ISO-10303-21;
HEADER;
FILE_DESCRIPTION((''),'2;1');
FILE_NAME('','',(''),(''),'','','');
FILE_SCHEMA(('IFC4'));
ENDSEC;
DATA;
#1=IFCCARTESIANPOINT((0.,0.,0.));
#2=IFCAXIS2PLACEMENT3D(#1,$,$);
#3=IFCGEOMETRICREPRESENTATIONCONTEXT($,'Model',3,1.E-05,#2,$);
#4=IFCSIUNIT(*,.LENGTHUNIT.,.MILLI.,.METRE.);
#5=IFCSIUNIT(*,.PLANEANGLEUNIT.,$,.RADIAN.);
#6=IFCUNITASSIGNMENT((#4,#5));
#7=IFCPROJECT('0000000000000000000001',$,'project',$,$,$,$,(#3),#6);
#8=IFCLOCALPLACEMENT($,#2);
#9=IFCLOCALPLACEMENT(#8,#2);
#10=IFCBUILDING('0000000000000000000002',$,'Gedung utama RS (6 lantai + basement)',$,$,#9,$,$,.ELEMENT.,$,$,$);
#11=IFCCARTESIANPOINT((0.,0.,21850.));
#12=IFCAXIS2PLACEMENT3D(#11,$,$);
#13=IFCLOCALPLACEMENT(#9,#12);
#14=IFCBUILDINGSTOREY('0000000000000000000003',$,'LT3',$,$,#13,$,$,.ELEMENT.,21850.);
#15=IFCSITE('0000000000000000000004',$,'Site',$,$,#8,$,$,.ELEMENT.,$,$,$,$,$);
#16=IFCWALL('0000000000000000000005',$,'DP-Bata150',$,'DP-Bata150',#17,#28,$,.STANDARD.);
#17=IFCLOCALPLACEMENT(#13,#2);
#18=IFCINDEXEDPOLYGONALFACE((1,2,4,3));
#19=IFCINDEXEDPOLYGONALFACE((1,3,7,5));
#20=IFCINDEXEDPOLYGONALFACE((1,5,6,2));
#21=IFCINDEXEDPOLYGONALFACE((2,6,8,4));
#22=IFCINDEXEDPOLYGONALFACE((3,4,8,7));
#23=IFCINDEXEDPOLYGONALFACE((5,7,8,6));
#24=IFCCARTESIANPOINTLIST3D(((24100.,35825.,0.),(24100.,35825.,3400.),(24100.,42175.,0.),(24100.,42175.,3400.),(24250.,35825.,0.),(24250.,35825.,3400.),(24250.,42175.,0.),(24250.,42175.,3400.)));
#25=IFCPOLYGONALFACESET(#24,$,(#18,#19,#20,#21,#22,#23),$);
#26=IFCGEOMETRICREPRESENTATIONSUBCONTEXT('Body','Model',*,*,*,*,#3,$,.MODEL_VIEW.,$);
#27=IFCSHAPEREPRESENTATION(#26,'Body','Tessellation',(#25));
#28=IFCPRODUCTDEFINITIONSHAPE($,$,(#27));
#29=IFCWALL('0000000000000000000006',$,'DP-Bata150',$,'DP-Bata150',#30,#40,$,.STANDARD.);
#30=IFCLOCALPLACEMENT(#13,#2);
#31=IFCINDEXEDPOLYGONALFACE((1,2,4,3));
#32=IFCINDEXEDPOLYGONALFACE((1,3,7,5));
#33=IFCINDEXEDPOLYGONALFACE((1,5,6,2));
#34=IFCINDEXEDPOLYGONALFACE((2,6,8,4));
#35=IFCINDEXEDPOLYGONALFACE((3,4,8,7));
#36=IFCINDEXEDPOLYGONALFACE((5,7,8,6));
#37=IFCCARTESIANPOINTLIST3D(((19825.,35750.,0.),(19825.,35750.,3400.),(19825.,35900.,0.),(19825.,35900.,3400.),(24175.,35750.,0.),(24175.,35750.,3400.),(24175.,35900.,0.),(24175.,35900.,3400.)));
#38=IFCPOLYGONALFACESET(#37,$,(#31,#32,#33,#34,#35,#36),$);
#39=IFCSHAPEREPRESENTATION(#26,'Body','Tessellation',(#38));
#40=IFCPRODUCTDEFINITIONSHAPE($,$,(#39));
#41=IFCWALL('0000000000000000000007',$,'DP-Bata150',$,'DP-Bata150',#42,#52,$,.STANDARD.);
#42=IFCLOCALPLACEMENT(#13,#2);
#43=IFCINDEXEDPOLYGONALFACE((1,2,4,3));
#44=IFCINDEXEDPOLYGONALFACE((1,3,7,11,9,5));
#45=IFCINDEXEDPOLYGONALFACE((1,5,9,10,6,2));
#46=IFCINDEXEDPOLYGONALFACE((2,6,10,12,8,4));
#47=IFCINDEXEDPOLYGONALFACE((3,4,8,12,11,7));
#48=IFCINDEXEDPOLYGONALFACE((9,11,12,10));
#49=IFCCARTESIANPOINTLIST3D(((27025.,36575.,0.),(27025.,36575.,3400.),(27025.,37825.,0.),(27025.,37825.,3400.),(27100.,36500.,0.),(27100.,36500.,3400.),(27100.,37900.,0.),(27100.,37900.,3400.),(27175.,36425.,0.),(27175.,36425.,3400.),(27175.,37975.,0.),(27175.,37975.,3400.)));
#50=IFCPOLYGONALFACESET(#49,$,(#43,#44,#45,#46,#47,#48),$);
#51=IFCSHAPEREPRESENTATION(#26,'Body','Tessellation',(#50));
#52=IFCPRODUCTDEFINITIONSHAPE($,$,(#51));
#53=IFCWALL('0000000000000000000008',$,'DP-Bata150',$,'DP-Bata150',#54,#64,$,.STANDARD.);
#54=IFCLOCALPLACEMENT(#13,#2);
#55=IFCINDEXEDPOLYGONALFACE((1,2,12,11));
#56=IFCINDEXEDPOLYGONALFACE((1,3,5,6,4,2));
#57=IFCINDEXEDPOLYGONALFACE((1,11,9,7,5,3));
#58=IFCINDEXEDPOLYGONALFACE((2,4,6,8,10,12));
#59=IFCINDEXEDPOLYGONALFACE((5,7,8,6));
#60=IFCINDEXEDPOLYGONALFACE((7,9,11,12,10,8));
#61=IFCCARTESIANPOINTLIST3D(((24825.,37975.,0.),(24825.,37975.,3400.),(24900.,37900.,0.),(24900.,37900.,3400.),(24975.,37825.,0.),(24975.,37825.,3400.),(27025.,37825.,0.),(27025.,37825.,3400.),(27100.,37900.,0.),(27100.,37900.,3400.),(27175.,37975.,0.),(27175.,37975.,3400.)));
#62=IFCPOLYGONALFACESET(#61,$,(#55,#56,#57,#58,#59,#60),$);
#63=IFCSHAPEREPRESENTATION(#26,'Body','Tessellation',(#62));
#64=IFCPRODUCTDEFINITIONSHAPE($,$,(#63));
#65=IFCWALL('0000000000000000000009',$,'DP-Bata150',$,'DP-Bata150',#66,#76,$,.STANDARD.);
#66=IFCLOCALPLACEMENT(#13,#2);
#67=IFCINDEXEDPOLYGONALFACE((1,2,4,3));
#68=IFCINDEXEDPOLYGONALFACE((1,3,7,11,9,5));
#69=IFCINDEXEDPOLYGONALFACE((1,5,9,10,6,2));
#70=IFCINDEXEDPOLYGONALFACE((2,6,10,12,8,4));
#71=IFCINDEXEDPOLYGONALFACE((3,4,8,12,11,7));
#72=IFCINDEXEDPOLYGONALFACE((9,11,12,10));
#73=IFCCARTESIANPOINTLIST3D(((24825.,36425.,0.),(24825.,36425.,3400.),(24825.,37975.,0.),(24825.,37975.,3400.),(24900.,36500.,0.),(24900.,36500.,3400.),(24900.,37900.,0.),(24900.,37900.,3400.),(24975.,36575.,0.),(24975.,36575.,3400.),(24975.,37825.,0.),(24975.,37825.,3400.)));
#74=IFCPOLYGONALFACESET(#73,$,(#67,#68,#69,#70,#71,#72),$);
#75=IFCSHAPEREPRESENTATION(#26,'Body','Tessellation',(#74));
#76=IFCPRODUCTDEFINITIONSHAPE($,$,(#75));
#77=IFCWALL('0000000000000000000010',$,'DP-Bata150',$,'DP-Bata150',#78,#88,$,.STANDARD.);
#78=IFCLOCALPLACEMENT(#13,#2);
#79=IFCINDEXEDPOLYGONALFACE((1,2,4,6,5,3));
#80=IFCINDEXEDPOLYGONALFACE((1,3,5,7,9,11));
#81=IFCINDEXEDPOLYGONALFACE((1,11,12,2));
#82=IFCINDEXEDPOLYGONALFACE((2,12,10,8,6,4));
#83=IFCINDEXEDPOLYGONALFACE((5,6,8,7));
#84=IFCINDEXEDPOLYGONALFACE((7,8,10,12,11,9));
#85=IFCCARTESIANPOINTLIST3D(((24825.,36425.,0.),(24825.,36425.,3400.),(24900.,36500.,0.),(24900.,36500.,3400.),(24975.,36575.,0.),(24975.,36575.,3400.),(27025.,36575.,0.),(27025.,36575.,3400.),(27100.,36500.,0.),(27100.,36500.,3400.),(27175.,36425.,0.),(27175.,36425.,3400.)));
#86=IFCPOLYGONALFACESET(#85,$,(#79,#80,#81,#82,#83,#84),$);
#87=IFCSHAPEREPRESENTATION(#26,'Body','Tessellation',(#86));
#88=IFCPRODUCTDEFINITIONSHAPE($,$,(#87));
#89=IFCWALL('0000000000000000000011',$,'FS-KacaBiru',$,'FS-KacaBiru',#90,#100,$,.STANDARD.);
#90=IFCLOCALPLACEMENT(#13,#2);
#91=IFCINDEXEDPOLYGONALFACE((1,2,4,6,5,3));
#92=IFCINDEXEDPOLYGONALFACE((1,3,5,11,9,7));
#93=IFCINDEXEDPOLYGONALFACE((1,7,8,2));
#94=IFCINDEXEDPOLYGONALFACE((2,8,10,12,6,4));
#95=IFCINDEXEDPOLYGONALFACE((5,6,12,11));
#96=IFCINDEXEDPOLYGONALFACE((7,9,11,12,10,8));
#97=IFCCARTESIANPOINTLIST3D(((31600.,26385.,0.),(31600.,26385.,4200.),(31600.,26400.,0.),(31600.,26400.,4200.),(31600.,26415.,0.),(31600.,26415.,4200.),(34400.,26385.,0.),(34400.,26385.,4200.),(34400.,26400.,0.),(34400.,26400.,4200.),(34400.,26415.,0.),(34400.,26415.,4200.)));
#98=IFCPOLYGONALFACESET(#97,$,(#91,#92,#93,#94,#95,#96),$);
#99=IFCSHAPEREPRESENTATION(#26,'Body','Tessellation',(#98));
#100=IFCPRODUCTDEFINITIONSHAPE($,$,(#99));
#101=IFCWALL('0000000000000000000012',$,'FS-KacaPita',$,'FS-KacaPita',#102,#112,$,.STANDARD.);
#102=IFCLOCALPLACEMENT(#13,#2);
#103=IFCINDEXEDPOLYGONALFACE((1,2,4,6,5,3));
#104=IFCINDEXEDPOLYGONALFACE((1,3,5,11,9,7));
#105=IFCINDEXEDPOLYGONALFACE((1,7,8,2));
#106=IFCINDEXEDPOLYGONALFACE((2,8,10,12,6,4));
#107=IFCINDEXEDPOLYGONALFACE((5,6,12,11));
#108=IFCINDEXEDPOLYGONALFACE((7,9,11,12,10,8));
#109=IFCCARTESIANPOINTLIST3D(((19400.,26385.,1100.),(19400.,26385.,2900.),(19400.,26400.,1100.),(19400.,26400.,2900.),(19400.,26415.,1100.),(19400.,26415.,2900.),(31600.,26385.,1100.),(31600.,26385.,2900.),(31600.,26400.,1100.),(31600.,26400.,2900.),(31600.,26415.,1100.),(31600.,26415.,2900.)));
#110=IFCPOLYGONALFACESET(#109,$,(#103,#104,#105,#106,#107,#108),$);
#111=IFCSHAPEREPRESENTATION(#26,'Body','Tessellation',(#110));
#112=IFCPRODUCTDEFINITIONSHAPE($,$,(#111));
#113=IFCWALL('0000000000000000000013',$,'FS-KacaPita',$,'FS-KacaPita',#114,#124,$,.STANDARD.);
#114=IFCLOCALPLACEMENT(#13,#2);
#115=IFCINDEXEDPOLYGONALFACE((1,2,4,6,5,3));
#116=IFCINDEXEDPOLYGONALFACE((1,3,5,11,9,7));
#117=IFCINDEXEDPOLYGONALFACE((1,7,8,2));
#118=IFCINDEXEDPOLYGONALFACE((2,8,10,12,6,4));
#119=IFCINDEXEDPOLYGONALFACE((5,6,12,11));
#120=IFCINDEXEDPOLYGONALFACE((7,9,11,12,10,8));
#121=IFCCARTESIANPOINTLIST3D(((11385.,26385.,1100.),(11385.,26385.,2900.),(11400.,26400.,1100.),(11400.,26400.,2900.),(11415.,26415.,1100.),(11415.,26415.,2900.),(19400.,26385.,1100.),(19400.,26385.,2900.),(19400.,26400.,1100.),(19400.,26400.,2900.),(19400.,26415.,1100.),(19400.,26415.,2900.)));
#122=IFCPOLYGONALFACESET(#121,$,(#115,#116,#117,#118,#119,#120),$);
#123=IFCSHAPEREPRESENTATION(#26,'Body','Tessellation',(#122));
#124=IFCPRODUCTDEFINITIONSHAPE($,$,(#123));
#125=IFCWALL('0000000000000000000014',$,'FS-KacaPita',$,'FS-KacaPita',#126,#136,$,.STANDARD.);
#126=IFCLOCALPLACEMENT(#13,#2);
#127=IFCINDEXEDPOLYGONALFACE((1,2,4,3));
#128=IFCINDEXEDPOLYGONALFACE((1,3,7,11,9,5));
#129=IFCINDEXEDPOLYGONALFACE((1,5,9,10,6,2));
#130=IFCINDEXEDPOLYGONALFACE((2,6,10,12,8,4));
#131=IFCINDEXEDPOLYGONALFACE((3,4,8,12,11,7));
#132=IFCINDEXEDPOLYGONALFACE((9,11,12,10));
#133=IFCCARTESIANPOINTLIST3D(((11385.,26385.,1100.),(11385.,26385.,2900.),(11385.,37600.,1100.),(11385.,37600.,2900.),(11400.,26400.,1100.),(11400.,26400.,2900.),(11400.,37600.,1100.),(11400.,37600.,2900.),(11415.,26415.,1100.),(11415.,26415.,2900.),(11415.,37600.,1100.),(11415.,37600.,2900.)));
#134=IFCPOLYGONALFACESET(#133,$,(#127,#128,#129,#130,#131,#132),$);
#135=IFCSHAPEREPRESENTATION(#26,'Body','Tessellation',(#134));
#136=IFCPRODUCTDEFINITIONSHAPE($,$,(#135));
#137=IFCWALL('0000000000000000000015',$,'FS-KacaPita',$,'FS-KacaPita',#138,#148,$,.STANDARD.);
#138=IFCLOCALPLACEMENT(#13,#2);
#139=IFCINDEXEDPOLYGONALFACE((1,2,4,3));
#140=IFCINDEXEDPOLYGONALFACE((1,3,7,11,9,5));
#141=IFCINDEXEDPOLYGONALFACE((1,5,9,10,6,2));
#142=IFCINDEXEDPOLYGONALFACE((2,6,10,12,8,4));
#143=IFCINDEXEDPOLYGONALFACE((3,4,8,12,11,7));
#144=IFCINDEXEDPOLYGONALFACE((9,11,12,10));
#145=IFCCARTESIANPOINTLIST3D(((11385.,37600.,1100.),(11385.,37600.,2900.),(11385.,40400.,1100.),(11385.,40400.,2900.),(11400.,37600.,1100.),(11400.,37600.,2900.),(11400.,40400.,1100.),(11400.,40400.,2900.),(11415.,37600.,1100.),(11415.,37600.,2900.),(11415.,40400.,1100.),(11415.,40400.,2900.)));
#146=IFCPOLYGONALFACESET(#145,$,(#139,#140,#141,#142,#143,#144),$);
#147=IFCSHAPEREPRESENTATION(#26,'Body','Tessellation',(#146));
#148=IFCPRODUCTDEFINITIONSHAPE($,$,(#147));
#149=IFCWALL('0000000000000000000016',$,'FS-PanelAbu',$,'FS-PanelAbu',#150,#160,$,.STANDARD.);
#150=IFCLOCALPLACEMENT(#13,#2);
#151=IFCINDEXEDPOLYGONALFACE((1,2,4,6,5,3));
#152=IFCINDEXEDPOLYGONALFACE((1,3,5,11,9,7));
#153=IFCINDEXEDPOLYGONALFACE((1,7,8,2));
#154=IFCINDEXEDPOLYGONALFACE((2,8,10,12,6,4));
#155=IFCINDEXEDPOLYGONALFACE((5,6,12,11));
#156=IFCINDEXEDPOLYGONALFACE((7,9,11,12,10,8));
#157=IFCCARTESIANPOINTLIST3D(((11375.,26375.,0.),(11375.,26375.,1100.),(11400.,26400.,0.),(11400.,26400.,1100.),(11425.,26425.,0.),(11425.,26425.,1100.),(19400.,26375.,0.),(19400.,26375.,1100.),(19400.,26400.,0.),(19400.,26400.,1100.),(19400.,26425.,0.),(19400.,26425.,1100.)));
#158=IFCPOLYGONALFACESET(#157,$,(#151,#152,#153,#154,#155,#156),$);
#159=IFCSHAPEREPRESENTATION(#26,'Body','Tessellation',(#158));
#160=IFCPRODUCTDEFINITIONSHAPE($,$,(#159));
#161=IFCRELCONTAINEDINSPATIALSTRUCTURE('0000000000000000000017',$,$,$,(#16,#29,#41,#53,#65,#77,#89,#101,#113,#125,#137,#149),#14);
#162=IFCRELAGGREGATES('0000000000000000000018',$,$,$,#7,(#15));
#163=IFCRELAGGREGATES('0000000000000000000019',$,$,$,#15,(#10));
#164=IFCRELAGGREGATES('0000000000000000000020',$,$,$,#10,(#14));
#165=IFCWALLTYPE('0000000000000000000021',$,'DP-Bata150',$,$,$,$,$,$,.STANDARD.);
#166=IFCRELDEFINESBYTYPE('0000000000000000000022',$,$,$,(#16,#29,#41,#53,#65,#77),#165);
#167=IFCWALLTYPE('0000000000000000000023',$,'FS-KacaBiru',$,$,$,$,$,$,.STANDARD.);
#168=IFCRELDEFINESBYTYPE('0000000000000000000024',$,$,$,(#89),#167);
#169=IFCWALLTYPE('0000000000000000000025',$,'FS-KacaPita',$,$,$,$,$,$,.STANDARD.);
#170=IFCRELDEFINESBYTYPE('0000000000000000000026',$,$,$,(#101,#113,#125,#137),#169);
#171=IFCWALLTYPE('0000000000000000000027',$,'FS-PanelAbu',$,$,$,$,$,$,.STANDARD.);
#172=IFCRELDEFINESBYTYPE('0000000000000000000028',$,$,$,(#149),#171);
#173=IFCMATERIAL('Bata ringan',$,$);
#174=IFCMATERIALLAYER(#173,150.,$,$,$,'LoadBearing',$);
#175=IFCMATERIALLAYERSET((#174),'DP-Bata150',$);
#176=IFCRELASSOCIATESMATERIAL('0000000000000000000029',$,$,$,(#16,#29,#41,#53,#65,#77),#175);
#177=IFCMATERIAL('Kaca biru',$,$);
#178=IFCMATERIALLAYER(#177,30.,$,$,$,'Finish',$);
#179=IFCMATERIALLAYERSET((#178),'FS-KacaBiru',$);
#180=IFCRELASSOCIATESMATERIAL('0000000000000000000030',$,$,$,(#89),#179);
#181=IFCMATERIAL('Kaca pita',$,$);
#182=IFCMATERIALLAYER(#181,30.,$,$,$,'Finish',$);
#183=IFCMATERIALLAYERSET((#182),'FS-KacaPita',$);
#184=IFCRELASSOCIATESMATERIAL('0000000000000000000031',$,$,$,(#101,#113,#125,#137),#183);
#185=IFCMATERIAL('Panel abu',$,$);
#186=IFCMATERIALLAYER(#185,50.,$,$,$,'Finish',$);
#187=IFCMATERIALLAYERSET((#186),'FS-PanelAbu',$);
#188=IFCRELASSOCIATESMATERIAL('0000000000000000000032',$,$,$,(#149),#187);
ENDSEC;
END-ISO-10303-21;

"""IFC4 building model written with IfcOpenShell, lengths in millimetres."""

from ifc_helpers import new_model, si_unit, frame, origin, place, context, subcontext, project, spatial, polyline, outline, extrude, material, layer, layer_set, layer_usage, type_object, element, save


model = new_model("IFC4")

# Units and contexts
model_context = context("Model", 3, precision=1e-05, world=origin())
body_context = subcontext(model_context, "Body", "Model", "MODEL_VIEW")
ifc_project = project(units=[si_unit("LENGTHUNIT", "METRE", prefix="MILLI"), si_unit("PLANEANGLEUNIT", "RADIAN")], contexts=[model_context])

# Site, building, storey
site_placement = place(None, origin())
site = spatial("IfcSite", under=ifc_project, at=site_placement, Name="Site", CompositionType="ELEMENT")
building_placement = place(site_placement, origin())
building = spatial("IfcBuilding", under=site, at=building_placement, Name="Gedung utama RS (6 lantai + basement)", CompositionType="ELEMENT")
storey_placement = place(building_placement, frame((0.0, 0.0, 21850.0)))
storey = spatial("IfcBuildingStorey", under=building, at=storey_placement, Name="LT3", CompositionType="ELEMENT", Elevation=21850.0)

# Shared definitions
ifc_material_1 = material(Name="Bata ringan")
ifc_layer_1 = layer(ifc_material_1, 150.0, Category="LoadBearing")
ifc_layer_set_1 = layer_set([ifc_layer_1], Name="DP-Bata150")
ifc_layer_usage_1 = layer_usage(ifc_layer_set_1, "AXIS2", "NEGATIVE", 75.0)
wall_type_1 = type_object("IfcWallType", Name="DP-Bata150", PredefinedType="STANDARD")

# Walls
wall_1_placement = place(storey_placement, frame((24175.0, 35825.0, 0.0), z_axis=(0.0, 0.0, 1.0), x_axis=(0.0, 1.0, 0.0)))
element("IfcWall", 1, at=wall_1_placement, inside=storey, type_object=wall_type_1, material=ifc_layer_usage_1, Name="DP-Bata150", ObjectType="DP-Bata150", PredefinedType="STANDARD", context=body_context, shape_type="SweptSolid", body=[
    extrude(outline(polyline([(0.0, -75.0), (0.0, 75.0), (6350.0, 75.0), (6350.0, -75.0), (0.0, -75.0)])), origin(), (0.0, 0.0, 1.0), 3400.0),
])
wall_2_placement = place(storey_placement, frame((19825.0, 35825.0, 0.0), z_axis=(0.0, 0.0, 1.0), x_axis=(1.0, 0.0, 0.0)))
element("IfcWall", 2, at=wall_2_placement, inside=storey, type_object=wall_type_1, material=ifc_layer_usage_1, Name="DP-Bata150", ObjectType="DP-Bata150", PredefinedType="STANDARD", context=body_context, shape_type="SweptSolid", body=[
    extrude(outline(polyline([(0.0, -75.0), (0.0, 75.0), (4350.0, 75.0), (4350.0, -75.0), (0.0, -75.0)])), origin(), (0.0, 0.0, 1.0), 3400.0),
])
wall_3_placement = place(storey_placement, frame((27100.0, 36500.0, 0.0), z_axis=(0.0, 0.0, 1.0), x_axis=(0.0, 1.0, 0.0)))
element("IfcWall", 3, at=wall_3_placement, inside=storey, type_object=wall_type_1, material=ifc_layer_usage_1, Name="DP-Bata150", ObjectType="DP-Bata150", PredefinedType="STANDARD", context=body_context, shape_type="SweptSolid", body=[
    extrude(outline(polyline([(-75.0, -75.0), (0.0, 0.0), (75.0, 75.0), (1325.0, 75.0), (1400.0, 0.0), (1475.0, -75.0), (-75.0, -75.0)])), origin(), (0.0, 0.0, 1.0), 3400.0),
])
wall_4_placement = place(storey_placement, frame((27100.0, 37900.0, 0.0), z_axis=(0.0, 0.0, 1.0), x_axis=(-1.0, 0.0, 0.0)))
element("IfcWall", 4, at=wall_4_placement, inside=storey, type_object=wall_type_1, material=ifc_layer_usage_1, Name="DP-Bata150", ObjectType="DP-Bata150", PredefinedType="STANDARD", context=body_context, shape_type="SweptSolid", body=[
    extrude(outline(polyline([(-75.0, -75.0), (0.0, 0.0), (75.0, 75.0), (2125.0, 75.0), (2200.0, 0.0), (2275.0, -75.0), (-75.0, -75.0)])), origin(), (0.0, 0.0, 1.0), 3400.0),
])
wall_5_placement = place(storey_placement, frame((24900.0, 37900.0, 0.0), z_axis=(0.0, 0.0, 1.0), x_axis=(0.0, -1.0, 0.0)))
element("IfcWall", 5, at=wall_5_placement, inside=storey, type_object=wall_type_1, material=ifc_layer_usage_1, Name="DP-Bata150", ObjectType="DP-Bata150", PredefinedType="STANDARD", context=body_context, shape_type="SweptSolid", body=[
    extrude(outline(polyline([(-75.0, -75.0), (0.0, 0.0), (75.0, 75.0), (1325.0, 75.0), (1400.0, 0.0), (1475.0, -75.0), (-75.0, -75.0)])), origin(), (0.0, 0.0, 1.0), 3400.0),
])
wall_6_placement = place(storey_placement, frame((24900.0, 36500.0, 0.0), z_axis=(0.0, 0.0, 1.0), x_axis=(1.0, 0.0, 0.0)))
element("IfcWall", 6, at=wall_6_placement, inside=storey, type_object=wall_type_1, material=ifc_layer_usage_1, Name="DP-Bata150", ObjectType="DP-Bata150", PredefinedType="STANDARD", context=body_context, shape_type="SweptSolid", body=[
    extrude(outline(polyline([(-75.0, -75.0), (0.0, 0.0), (75.0, 75.0), (2125.0, 75.0), (2200.0, 0.0), (2275.0, -75.0), (-75.0, -75.0)])), origin(), (0.0, 0.0, 1.0), 3400.0),
])
ifc_material_2 = material(Name="Kaca biru")
ifc_layer_2 = layer(ifc_material_2, 30.0, Category="Finish")
ifc_layer_set_2 = layer_set([ifc_layer_2], Name="FS-KacaBiru")
ifc_layer_usage_2 = layer_usage(ifc_layer_set_2, "AXIS2", "NEGATIVE", 15.0)
wall_type_2 = type_object("IfcWallType", Name="FS-KacaBiru", PredefinedType="STANDARD")
wall_7_placement = place(storey_placement, frame((34400.0, 26400.0, 0.0), z_axis=(0.0, 0.0, 1.0), x_axis=(-1.0, 0.0, 0.0)))
element("IfcWall", 7, at=wall_7_placement, inside=storey, type_object=wall_type_2, material=ifc_layer_usage_2, Name="FS-KacaBiru", ObjectType="FS-KacaBiru", PredefinedType="STANDARD", context=body_context, shape_type="SweptSolid", body=[
    extrude(outline(polyline([(0.0, -15.0), (0.0, 0.0), (0.0, 15.0), (2800.0, 15.0), (2800.0, 0.0), (2800.0, -15.0), (0.0, -15.0)])), origin(), (0.0, 0.0, 1.0), 4200.0),
])
ifc_material_3 = material(Name="Kaca pita")
ifc_layer_3 = layer(ifc_material_3, 30.0, Category="Finish")
ifc_layer_set_3 = layer_set([ifc_layer_3], Name="FS-KacaPita")
ifc_layer_usage_3 = layer_usage(ifc_layer_set_3, "AXIS2", "NEGATIVE", 15.0)
wall_type_3 = type_object("IfcWallType", Name="FS-KacaPita", PredefinedType="STANDARD")
wall_8_placement = place(storey_placement, frame((31600.0, 26400.0, 1100.0), z_axis=(0.0, 0.0, 1.0), x_axis=(-1.0, 0.0, 0.0)))
element("IfcWall", 8, at=wall_8_placement, inside=storey, type_object=wall_type_3, material=ifc_layer_usage_3, Name="FS-KacaPita", ObjectType="FS-KacaPita", PredefinedType="STANDARD", context=body_context, shape_type="SweptSolid", body=[
    extrude(outline(polyline([(0.0, -15.0), (0.0, 0.0), (0.0, 15.0), (12200.0, 15.0), (12200.0, 0.0), (12200.0, -15.0), (0.0, -15.0)])), origin(), (0.0, 0.0, 1.0), 1800.0),
])
wall_9_placement = place(storey_placement, frame((19400.0, 26400.0, 1100.0), z_axis=(0.0, 0.0, 1.0), x_axis=(-1.0, 0.0, 0.0)))
element("IfcWall", 9, at=wall_9_placement, inside=storey, type_object=wall_type_3, material=ifc_layer_usage_3, Name="FS-KacaPita", ObjectType="FS-KacaPita", PredefinedType="STANDARD", context=body_context, shape_type="SweptSolid", body=[
    extrude(outline(polyline([(0.0, -15.0), (0.0, 0.0), (0.0, 15.0), (8015.0, 15.0), (8000.0, 0.0), (7985.0, -15.0), (0.0, -15.0)])), origin(), (0.0, 0.0, 1.0), 1800.0),
])
wall_10_placement = place(storey_placement, frame((11400.0, 26400.0, 1100.0), z_axis=(0.0, 0.0, 1.0), x_axis=(0.0, 1.0, 0.0)))
element("IfcWall", 10, at=wall_10_placement, inside=storey, type_object=wall_type_3, material=ifc_layer_usage_3, Name="FS-KacaPita", ObjectType="FS-KacaPita", PredefinedType="STANDARD", context=body_context, shape_type="SweptSolid", body=[
    extrude(outline(polyline([(15.0, -15.0), (0.0, 0.0), (-15.0, 15.0), (11200.0, 15.0), (11200.0, 0.0), (11200.0, -15.0), (15.0, -15.0)])), origin(), (0.0, 0.0, 1.0), 1800.0),
])
wall_11_placement = place(storey_placement, frame((11400.0, 37600.0, 1100.0), z_axis=(0.0, 0.0, 1.0), x_axis=(0.0, 1.0, 0.0)))
element("IfcWall", 11, at=wall_11_placement, inside=storey, type_object=wall_type_3, material=ifc_layer_usage_3, Name="FS-KacaPita", ObjectType="FS-KacaPita", PredefinedType="STANDARD", context=body_context, shape_type="SweptSolid", body=[
    extrude(outline(polyline([(0.0, -15.0), (0.0, 0.0), (0.0, 15.0), (2800.0, 15.0), (2800.0, 0.0), (2800.0, -15.0), (0.0, -15.0)])), origin(), (0.0, 0.0, 1.0), 1800.0),
])
ifc_material_4 = material(Name="Panel abu")
ifc_layer_4 = layer(ifc_material_4, 50.0, Category="Finish")
ifc_layer_set_4 = layer_set([ifc_layer_4], Name="FS-PanelAbu")
ifc_layer_usage_4 = layer_usage(ifc_layer_set_4, "AXIS2", "NEGATIVE", 25.0)
wall_type_4 = type_object("IfcWallType", Name="FS-PanelAbu", PredefinedType="STANDARD")
wall_12_placement = place(storey_placement, frame((19400.0, 26400.0, 0.0), z_axis=(0.0, 0.0, 1.0), x_axis=(-1.0, 0.0, 0.0)))
element("IfcWall", 12, at=wall_12_placement, inside=storey, type_object=wall_type_4, material=ifc_layer_usage_4, Name="FS-PanelAbu", ObjectType="FS-PanelAbu", PredefinedType="STANDARD", context=body_context, shape_type="SweptSolid", body=[
    extrude(outline(polyline([(0.0, -25.0), (0.0, 0.0), (0.0, 25.0), (8025.0, 25.0), (8000.0, 0.0), (7975.0, -25.0), (0.0, -25.0)])), origin(), (0.0, 0.0, 1.0), 1100.0),
])

save(model, "model.ifc")
